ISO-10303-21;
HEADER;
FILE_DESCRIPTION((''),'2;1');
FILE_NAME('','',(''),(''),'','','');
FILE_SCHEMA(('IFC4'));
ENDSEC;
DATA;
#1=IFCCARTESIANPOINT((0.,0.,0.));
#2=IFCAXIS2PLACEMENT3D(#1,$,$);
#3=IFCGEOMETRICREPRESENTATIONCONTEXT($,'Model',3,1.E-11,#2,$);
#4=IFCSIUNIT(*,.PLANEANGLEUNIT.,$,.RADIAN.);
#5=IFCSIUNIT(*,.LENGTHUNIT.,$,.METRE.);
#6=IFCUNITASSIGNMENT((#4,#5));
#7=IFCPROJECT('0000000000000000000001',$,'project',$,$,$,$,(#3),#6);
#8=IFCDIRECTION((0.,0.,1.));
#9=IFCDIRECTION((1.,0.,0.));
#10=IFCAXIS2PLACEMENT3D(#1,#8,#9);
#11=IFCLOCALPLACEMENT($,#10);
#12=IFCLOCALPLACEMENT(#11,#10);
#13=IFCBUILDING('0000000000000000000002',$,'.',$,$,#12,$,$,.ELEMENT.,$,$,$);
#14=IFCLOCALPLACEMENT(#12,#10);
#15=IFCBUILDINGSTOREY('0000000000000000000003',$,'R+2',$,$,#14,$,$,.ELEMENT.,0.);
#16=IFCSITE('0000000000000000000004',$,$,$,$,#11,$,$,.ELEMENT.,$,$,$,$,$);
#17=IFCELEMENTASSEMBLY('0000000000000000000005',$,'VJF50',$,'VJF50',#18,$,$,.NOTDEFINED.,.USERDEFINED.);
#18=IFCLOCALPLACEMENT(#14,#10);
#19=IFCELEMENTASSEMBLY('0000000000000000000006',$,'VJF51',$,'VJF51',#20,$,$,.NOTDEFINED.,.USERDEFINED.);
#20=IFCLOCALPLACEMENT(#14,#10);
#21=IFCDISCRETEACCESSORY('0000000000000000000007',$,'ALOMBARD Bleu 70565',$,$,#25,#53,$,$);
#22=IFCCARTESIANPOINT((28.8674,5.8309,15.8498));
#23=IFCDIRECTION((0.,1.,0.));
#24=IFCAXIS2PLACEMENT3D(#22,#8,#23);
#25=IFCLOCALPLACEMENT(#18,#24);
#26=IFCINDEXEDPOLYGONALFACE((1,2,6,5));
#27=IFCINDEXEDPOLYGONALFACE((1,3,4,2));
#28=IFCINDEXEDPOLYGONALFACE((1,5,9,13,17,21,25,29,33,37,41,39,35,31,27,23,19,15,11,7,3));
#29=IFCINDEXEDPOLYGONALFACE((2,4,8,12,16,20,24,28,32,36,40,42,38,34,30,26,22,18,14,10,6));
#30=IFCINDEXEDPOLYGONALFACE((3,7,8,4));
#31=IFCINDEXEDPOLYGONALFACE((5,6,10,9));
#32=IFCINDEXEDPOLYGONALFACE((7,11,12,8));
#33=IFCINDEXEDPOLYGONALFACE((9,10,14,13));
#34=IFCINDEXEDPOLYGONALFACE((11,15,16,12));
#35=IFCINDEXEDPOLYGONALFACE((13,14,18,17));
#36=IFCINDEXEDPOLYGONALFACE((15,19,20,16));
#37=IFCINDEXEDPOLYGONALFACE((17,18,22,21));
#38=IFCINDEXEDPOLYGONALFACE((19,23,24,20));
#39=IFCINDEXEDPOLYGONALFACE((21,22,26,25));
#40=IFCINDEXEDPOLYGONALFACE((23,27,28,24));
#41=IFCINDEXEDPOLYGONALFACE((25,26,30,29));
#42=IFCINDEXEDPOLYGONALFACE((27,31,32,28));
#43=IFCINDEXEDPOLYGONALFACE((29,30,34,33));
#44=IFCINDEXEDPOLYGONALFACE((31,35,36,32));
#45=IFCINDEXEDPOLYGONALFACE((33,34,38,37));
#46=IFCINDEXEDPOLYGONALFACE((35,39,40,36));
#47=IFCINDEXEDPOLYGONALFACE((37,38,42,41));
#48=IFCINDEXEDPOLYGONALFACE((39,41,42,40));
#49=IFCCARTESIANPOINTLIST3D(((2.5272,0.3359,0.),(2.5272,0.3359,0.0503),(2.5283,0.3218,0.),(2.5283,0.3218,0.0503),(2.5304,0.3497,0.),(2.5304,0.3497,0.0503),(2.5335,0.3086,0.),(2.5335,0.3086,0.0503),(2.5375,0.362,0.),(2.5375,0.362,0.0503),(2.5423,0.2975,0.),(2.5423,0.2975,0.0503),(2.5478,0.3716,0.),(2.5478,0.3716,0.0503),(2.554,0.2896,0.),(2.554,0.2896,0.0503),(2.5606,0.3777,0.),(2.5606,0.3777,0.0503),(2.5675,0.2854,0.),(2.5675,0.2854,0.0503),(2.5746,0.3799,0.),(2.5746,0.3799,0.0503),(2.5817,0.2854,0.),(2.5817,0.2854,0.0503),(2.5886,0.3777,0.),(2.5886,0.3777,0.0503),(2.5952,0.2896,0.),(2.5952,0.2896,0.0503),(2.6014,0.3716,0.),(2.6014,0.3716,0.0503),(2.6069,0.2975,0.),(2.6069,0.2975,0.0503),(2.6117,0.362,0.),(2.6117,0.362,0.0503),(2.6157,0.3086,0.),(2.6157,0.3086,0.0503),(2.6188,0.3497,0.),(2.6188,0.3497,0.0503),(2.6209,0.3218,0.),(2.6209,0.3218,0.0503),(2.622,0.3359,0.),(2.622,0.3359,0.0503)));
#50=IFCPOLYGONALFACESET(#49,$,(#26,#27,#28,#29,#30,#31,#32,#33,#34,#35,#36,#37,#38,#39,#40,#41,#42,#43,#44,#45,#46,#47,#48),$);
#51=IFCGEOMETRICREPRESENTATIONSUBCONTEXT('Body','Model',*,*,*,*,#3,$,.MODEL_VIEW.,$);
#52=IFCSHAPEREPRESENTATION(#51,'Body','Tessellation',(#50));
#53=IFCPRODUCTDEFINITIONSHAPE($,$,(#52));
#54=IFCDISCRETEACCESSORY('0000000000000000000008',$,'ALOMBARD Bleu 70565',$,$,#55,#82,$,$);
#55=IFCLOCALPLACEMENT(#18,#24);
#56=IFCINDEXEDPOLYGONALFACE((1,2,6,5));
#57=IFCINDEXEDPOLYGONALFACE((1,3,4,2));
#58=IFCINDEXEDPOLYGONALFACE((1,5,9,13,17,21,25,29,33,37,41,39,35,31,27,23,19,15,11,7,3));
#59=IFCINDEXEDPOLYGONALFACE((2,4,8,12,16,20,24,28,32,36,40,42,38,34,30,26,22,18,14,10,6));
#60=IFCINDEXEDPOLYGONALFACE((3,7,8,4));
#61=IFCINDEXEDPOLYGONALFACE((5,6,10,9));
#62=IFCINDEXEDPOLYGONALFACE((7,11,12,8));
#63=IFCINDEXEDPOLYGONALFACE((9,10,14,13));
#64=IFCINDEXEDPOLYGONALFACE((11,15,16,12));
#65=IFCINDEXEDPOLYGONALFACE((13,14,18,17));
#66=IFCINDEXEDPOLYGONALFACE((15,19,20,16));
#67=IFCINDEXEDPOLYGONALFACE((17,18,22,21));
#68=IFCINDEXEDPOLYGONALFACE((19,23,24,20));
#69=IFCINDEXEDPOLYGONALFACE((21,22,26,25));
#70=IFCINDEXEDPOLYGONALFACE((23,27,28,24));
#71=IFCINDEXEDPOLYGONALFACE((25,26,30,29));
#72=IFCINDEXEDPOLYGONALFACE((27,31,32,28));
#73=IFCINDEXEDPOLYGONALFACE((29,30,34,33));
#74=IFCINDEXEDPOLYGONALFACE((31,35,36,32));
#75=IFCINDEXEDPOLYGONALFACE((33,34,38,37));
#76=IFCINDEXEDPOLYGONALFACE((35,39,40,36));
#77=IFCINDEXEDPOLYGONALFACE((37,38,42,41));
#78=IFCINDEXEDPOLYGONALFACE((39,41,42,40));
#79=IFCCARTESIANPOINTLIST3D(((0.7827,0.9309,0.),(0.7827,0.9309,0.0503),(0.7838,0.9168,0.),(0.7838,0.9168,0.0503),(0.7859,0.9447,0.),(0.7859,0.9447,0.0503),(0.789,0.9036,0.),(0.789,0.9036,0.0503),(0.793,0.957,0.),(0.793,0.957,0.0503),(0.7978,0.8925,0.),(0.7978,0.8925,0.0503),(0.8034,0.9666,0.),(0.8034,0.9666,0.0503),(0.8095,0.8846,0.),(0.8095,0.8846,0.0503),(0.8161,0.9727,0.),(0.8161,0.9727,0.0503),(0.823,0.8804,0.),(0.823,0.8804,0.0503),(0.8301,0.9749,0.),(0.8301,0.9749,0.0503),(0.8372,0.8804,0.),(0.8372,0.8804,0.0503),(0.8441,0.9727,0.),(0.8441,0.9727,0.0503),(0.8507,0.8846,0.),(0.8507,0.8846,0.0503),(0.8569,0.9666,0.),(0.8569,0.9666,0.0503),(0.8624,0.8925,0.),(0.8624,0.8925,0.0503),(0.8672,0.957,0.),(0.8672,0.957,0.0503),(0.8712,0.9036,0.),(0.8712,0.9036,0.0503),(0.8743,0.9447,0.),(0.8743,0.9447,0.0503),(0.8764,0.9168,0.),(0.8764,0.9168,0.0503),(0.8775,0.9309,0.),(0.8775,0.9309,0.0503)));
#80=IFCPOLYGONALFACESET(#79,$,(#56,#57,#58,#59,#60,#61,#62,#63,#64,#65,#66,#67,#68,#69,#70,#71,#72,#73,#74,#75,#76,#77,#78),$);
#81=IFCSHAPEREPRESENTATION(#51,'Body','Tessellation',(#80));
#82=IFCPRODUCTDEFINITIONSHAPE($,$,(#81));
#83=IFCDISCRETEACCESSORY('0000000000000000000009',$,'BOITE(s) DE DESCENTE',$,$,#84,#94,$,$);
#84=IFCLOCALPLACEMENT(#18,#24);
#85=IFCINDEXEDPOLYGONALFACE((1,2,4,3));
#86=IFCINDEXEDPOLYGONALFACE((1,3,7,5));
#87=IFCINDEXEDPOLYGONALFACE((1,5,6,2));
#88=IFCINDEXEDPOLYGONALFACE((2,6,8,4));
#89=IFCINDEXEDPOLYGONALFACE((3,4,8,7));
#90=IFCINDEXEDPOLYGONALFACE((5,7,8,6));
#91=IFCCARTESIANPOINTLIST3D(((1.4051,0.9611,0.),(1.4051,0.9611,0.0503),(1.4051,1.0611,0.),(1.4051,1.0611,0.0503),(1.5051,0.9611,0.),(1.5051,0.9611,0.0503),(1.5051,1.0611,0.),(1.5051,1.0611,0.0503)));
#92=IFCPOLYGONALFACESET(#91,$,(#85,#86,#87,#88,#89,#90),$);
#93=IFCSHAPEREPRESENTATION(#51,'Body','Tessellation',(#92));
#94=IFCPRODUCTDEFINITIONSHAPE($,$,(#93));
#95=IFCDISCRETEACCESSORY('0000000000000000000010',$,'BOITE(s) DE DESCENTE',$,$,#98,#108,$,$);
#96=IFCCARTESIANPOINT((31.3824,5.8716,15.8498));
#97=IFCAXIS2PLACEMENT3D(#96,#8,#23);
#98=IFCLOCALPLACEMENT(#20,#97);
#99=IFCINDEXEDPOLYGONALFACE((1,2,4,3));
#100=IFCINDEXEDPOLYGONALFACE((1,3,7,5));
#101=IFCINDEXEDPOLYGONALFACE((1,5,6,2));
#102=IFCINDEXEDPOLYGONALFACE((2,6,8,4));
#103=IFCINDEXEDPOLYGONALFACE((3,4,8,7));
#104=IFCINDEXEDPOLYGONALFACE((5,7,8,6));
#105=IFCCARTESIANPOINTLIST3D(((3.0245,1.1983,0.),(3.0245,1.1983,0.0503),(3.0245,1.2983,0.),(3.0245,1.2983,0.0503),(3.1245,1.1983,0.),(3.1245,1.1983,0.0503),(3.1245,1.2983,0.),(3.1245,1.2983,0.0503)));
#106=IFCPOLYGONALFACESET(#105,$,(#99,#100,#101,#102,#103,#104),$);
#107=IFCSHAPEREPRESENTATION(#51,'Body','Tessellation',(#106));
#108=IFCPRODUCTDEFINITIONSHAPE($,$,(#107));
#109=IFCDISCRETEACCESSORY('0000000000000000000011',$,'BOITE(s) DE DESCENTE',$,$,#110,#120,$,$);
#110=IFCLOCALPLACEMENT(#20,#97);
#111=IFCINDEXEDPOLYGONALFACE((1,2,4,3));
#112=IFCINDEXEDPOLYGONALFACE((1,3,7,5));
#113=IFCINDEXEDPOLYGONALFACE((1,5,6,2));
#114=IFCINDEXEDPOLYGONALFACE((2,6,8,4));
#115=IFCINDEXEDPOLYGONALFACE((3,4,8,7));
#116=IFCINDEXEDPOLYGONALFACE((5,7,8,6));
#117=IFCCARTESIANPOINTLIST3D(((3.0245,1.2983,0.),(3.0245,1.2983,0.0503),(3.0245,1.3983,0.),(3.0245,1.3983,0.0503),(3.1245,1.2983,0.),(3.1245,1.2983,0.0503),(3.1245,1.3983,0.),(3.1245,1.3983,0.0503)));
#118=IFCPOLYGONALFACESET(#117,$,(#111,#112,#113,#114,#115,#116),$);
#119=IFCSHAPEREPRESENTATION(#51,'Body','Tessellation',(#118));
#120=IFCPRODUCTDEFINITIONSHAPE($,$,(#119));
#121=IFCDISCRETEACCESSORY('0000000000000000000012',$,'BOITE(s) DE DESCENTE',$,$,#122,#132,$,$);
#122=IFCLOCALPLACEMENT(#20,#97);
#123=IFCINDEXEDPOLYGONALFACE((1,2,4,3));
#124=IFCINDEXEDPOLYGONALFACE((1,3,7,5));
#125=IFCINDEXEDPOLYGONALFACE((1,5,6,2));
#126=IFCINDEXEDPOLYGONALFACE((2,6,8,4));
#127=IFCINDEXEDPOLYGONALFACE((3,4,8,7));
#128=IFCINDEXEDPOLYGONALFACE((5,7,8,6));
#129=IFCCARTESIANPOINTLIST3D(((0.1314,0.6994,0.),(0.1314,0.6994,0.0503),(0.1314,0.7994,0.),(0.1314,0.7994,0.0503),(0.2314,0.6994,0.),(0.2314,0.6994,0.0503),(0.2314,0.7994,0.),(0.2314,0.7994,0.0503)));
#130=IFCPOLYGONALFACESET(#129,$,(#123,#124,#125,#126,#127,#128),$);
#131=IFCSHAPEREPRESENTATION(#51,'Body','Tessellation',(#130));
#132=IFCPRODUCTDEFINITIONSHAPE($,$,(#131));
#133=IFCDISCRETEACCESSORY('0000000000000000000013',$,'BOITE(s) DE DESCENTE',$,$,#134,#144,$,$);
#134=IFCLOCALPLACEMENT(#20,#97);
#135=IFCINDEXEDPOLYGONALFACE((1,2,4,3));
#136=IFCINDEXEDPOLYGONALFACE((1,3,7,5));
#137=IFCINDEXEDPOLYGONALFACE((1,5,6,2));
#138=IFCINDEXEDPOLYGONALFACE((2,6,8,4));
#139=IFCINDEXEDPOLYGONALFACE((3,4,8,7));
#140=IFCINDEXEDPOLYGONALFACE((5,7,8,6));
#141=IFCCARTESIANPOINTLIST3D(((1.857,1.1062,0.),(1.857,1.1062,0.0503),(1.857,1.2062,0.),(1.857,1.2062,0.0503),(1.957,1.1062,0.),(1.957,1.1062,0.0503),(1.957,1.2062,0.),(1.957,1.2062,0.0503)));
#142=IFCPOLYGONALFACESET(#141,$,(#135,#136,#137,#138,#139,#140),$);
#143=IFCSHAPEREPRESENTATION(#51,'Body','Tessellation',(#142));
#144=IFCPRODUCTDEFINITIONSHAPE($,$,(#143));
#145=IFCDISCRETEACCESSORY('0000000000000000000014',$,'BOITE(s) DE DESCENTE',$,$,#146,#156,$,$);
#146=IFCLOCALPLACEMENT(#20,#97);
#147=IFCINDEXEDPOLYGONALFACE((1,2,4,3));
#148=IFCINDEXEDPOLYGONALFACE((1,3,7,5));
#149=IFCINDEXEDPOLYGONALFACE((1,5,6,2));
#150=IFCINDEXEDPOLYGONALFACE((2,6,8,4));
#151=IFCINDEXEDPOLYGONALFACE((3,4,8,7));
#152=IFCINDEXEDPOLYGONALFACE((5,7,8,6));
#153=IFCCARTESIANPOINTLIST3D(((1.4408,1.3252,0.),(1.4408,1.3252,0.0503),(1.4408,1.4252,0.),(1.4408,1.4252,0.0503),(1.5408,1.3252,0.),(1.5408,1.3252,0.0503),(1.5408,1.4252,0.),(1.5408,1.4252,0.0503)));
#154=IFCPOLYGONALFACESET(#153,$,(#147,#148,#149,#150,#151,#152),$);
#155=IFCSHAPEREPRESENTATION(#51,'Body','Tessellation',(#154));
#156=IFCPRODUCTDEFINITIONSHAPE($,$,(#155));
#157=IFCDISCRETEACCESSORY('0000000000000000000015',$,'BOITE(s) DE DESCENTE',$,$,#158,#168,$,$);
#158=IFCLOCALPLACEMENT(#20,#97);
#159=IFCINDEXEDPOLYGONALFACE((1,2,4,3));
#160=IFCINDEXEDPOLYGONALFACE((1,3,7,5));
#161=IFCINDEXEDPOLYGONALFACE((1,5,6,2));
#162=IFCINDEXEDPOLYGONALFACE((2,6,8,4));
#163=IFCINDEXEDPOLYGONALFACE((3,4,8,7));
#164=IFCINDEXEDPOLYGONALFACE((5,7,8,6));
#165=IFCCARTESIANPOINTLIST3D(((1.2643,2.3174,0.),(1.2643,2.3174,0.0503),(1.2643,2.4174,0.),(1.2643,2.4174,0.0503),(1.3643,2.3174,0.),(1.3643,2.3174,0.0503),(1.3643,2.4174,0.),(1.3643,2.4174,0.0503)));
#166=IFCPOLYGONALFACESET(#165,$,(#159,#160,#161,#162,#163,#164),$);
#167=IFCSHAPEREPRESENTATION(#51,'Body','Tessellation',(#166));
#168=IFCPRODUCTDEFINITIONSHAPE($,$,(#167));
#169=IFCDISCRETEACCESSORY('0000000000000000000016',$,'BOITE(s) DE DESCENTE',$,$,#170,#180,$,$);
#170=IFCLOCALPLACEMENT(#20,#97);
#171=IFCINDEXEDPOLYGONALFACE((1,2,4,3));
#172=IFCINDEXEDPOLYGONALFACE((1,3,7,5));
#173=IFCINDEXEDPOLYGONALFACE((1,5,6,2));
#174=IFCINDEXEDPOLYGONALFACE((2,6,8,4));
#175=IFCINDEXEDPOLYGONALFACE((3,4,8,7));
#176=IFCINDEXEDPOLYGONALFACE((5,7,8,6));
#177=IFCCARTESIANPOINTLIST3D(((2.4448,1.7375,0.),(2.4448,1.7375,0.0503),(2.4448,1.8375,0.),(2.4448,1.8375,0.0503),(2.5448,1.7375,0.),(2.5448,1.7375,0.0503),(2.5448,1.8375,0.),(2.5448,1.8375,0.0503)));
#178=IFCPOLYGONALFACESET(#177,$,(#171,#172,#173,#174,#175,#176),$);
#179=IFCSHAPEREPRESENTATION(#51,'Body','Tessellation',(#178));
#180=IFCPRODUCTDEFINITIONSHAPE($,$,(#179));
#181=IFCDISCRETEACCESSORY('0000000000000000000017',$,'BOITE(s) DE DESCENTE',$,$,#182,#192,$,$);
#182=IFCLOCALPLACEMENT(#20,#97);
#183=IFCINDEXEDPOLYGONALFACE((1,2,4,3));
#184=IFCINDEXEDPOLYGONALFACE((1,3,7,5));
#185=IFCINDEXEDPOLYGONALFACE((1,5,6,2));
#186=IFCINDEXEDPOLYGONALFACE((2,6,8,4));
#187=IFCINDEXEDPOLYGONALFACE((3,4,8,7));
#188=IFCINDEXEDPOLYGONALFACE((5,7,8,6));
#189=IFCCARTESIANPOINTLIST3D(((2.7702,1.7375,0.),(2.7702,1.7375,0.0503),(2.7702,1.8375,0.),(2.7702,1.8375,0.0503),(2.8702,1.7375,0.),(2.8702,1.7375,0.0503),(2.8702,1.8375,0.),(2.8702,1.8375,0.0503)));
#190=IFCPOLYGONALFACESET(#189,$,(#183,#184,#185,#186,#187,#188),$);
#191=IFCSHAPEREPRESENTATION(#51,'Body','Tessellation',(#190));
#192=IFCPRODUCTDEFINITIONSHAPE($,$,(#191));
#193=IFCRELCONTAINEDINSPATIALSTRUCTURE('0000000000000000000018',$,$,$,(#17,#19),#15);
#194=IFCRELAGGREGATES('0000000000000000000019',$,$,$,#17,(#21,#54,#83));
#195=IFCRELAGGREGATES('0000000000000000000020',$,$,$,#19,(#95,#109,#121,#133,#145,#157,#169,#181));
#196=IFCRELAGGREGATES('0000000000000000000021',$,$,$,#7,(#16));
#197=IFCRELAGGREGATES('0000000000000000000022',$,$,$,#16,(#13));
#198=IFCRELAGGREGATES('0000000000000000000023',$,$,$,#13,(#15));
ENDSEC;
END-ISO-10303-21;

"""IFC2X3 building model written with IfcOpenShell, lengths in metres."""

from ifc_helpers import new_model, si_unit, frame, frame_2d, origin, origin_with_axes, place, context, subcontext, project, spatial, polyline, circle, outline, extrude, element, aggregate, save


model = new_model("IFC2X3")

# Units and contexts
model_context = context("Model", 3, precision=1e-11, world=origin())
body_context = subcontext(model_context, "Body", "Model", "MODEL_VIEW")
ifc_project = project(units=[si_unit("PLANEANGLEUNIT", "RADIAN"), si_unit("LENGTHUNIT", "METRE")], contexts=[model_context])

# Site, building, storey
site_placement = place(None, origin_with_axes())
site = spatial("IfcSite", under=ifc_project, at=site_placement, CompositionType="ELEMENT")
building_placement = place(site_placement, origin_with_axes())
building = spatial("IfcBuilding", under=site, at=building_placement, Name=".", CompositionType="ELEMENT")
storey_placement = place(building_placement, origin_with_axes())
storey = spatial("IfcBuildingStorey", under=building, at=storey_placement, Name="R+2", CompositionType="ELEMENT", Elevation=0.0)

# Element assemblies
assembly_1_placement = place(storey_placement, origin_with_axes())
assembly_1 = element("IfcElementAssembly", 1, at=assembly_1_placement, inside=storey, Name="VJF50", ObjectType="VJF50", AssemblyPlace="NOTDEFINED", PredefinedType="USERDEFINED")
assembly_2_placement = place(storey_placement, origin_with_axes())
assembly_2 = element("IfcElementAssembly", 2, at=assembly_2_placement, inside=storey, Name="VJF51", ObjectType="VJF51", AssemblyPlace="NOTDEFINED", PredefinedType="USERDEFINED")

# Discrete accessories
discrete_accessory_1_placement = place(assembly_1_placement, frame((28.8674, 5.8309, 15.8498), z_axis=(0.0, 0.0, 1.0), x_axis=(0.0, 1.0, 0.0)))
discrete_accessory_1 = element("IfcDiscreteAccessory", 3, at=discrete_accessory_1_placement, Name="ALOMBARD Bleu 70565", context=body_context, shape_type="SweptSolid", body=[
    extrude(circle(Radius=0.0475, at=frame_2d((0.3324, -2.5746), x_axis=(1.0, 0.0))), frame((0.0, 0.0, 0.0), z_axis=(0.0, 0.0, 1.0), x_axis=(0.0, 1.0, 0.0)), (0.0, 0.0, 1.0), 0.0503),
])
discrete_accessory_2_placement = place(assembly_1_placement, frame((28.8674, 5.8309, 15.8498), z_axis=(0.0, 0.0, 1.0), x_axis=(0.0, 1.0, 0.0)))
discrete_accessory_2 = element("IfcDiscreteAccessory", 4, at=discrete_accessory_2_placement, Name="ALOMBARD Bleu 70565", context=body_context, shape_type="SweptSolid", body=[
    extrude(circle(Radius=0.0475, at=frame_2d((0.9274, -0.8301), x_axis=(1.0, 0.0))), frame((0.0, 0.0, 0.0), z_axis=(0.0, 0.0, 1.0), x_axis=(0.0, 1.0, 0.0)), (0.0, 0.0, 1.0), 0.0503),
])
discrete_accessory_3_placement = place(assembly_1_placement, frame((28.8674, 5.8309, 15.8498), z_axis=(0.0, 0.0, 1.0), x_axis=(0.0, 1.0, 0.0)))
discrete_accessory_3 = element("IfcDiscreteAccessory", 5, at=discrete_accessory_3_placement, Name="BOITE(s) DE DESCENTE", context=body_context, shape_type="SweptSolid", body=[
    extrude(outline(polyline([(0.961, -1.4051), (0.961, -1.5051), (1.0611, -1.5051), (1.0611, -1.4051), (0.961, -1.4051)])), frame((0.0, 0.0, 0.0), z_axis=(0.0, 0.0, 1.0), x_axis=(0.0, 1.0, 0.0)), (0.0, 0.0, 1.0), 0.0503),
])
aggregate(assembly_1, [discrete_accessory_1, discrete_accessory_2, discrete_accessory_3])
discrete_accessory_4_placement = place(assembly_2_placement, frame((31.3824, 5.8716, 15.8498), z_axis=(0.0, 0.0, 1.0), x_axis=(0.0, 1.0, 0.0)))
discrete_accessory_4 = element("IfcDiscreteAccessory", 6, at=discrete_accessory_4_placement, Name="BOITE(s) DE DESCENTE", context=body_context, shape_type="SweptSolid", body=[
    extrude(outline(polyline([(1.1983, -3.0245), (1.1983, -3.1245), (1.2983, -3.1245), (1.2983, -3.0245), (1.1983, -3.0245)])), frame((0.0, 0.0, 0.0), z_axis=(0.0, 0.0, 1.0), x_axis=(0.0, 1.0, 0.0)), (0.0, 0.0, 1.0), 0.0503),
])
discrete_accessory_5_placement = place(assembly_2_placement, frame((31.3824, 5.8716, 15.8498), z_axis=(0.0, 0.0, 1.0), x_axis=(0.0, 1.0, 0.0)))
discrete_accessory_5 = element("IfcDiscreteAccessory", 7, at=discrete_accessory_5_placement, Name="BOITE(s) DE DESCENTE", context=body_context, shape_type="SweptSolid", body=[
    extrude(outline(polyline([(1.2983, -3.0245), (1.2983, -3.1245), (1.3983, -3.1245), (1.3983, -3.0245), (1.2983, -3.0245)])), frame((0.0, 0.0, 0.0), z_axis=(0.0, 0.0, 1.0), x_axis=(0.0, 1.0, 0.0)), (0.0, 0.0, 1.0), 0.0503),
])
discrete_accessory_6_placement = place(assembly_2_placement, frame((31.3824, 5.8716, 15.8498), z_axis=(0.0, 0.0, 1.0), x_axis=(0.0, 1.0, 0.0)))
discrete_accessory_6 = element("IfcDiscreteAccessory", 8, at=discrete_accessory_6_placement, Name="BOITE(s) DE DESCENTE", context=body_context, shape_type="SweptSolid", body=[
    extrude(outline(polyline([(0.6994, -0.1314), (0.6994, -0.2314), (0.7994, -0.2314), (0.7994, -0.1314), (0.6994, -0.1314)])), frame((0.0, 0.0, 0.0), z_axis=(0.0, 0.0, 1.0), x_axis=(0.0, 1.0, 0.0)), (0.0, 0.0, 1.0), 0.0503),
])
discrete_accessory_7_placement = place(assembly_2_placement, frame((31.3824, 5.8716, 15.8498), z_axis=(0.0, 0.0, 1.0), x_axis=(0.0, 1.0, 0.0)))
discrete_accessory_7 = element("IfcDiscreteAccessory", 9, at=discrete_accessory_7_placement, Name="BOITE(s) DE DESCENTE", context=body_context, shape_type="SweptSolid", body=[
    extrude(outline(polyline([(1.1062, -1.857), (1.1062, -1.957), (1.2062, -1.957), (1.2062, -1.857), (1.1062, -1.857)])), frame((0.0, 0.0, 0.0), z_axis=(0.0, 0.0, 1.0), x_axis=(0.0, 1.0, 0.0)), (0.0, 0.0, 1.0), 0.0503),
])
discrete_accessory_8_placement = place(assembly_2_placement, frame((31.3824, 5.8716, 15.8498), z_axis=(0.0, 0.0, 1.0), x_axis=(0.0, 1.0, 0.0)))
discrete_accessory_8 = element("IfcDiscreteAccessory", 10, at=discrete_accessory_8_placement, Name="BOITE(s) DE DESCENTE", context=body_context, shape_type="SweptSolid", body=[
    extrude(outline(polyline([(1.3252, -1.4408), (1.3252, -1.5408), (1.4252, -1.5408), (1.4252, -1.4408), (1.3252, -1.4408)])), frame((0.0, 0.0, 0.0), z_axis=(0.0, 0.0, 1.0), x_axis=(0.0, 1.0, 0.0)), (0.0, 0.0, 1.0), 0.0503),
])
discrete_accessory_9_placement = place(assembly_2_placement, frame((31.3824, 5.8716, 15.8498), z_axis=(0.0, 0.0, 1.0), x_axis=(0.0, 1.0, 0.0)))
discrete_accessory_9 = element("IfcDiscreteAccessory", 11, at=discrete_accessory_9_placement, Name="BOITE(s) DE DESCENTE", context=body_context, shape_type="SweptSolid", body=[
    extrude(outline(polyline([(2.3174, -1.2643), (2.3174, -1.3643), (2.4174, -1.3643), (2.4174, -1.2643), (2.3174, -1.2643)])), frame((0.0, 0.0, 0.0), z_axis=(0.0, 0.0, 1.0), x_axis=(0.0, 1.0, 0.0)), (0.0, 0.0, 1.0), 0.0503),
])
discrete_accessory_10_placement = place(assembly_2_placement, frame((31.3824, 5.8716, 15.8498), z_axis=(0.0, 0.0, 1.0), x_axis=(0.0, 1.0, 0.0)))
discrete_accessory_10 = element("IfcDiscreteAccessory", 12, at=discrete_accessory_10_placement, Name="BOITE(s) DE DESCENTE", context=body_context, shape_type="SweptSolid", body=[
    extrude(outline(polyline([(1.7375, -2.4448), (1.7375, -2.5448), (1.8375, -2.5448), (1.8375, -2.4448), (1.7375, -2.4448)])), frame((0.0, 0.0, 0.0), z_axis=(0.0, 0.0, 1.0), x_axis=(0.0, 1.0, 0.0)), (0.0, 0.0, 1.0), 0.0503),
])
discrete_accessory_11_placement = place(assembly_2_placement, frame((31.3824, 5.8716, 15.8498), z_axis=(0.0, 0.0, 1.0), x_axis=(0.0, 1.0, 0.0)))
discrete_accessory_11 = element("IfcDiscreteAccessory", 13, at=discrete_accessory_11_placement, Name="BOITE(s) DE DESCENTE", context=body_context, shape_type="SweptSolid", body=[
    extrude(outline(polyline([(1.7375, -2.7702), (1.7375, -2.8702), (1.8375, -2.8702), (1.8375, -2.7702), (1.7375, -2.7702)])), frame((0.0, 0.0, 0.0), z_axis=(0.0, 0.0, 1.0), x_axis=(0.0, 1.0, 0.0)), (0.0, 0.0, 1.0), 0.0503),
])
aggregate(assembly_2, [discrete_accessory_4, discrete_accessory_5, discrete_accessory_6, discrete_accessory_7, discrete_accessory_8, discrete_accessory_9, discrete_accessory_10, discrete_accessory_11])

save(model, "model.ifc")
